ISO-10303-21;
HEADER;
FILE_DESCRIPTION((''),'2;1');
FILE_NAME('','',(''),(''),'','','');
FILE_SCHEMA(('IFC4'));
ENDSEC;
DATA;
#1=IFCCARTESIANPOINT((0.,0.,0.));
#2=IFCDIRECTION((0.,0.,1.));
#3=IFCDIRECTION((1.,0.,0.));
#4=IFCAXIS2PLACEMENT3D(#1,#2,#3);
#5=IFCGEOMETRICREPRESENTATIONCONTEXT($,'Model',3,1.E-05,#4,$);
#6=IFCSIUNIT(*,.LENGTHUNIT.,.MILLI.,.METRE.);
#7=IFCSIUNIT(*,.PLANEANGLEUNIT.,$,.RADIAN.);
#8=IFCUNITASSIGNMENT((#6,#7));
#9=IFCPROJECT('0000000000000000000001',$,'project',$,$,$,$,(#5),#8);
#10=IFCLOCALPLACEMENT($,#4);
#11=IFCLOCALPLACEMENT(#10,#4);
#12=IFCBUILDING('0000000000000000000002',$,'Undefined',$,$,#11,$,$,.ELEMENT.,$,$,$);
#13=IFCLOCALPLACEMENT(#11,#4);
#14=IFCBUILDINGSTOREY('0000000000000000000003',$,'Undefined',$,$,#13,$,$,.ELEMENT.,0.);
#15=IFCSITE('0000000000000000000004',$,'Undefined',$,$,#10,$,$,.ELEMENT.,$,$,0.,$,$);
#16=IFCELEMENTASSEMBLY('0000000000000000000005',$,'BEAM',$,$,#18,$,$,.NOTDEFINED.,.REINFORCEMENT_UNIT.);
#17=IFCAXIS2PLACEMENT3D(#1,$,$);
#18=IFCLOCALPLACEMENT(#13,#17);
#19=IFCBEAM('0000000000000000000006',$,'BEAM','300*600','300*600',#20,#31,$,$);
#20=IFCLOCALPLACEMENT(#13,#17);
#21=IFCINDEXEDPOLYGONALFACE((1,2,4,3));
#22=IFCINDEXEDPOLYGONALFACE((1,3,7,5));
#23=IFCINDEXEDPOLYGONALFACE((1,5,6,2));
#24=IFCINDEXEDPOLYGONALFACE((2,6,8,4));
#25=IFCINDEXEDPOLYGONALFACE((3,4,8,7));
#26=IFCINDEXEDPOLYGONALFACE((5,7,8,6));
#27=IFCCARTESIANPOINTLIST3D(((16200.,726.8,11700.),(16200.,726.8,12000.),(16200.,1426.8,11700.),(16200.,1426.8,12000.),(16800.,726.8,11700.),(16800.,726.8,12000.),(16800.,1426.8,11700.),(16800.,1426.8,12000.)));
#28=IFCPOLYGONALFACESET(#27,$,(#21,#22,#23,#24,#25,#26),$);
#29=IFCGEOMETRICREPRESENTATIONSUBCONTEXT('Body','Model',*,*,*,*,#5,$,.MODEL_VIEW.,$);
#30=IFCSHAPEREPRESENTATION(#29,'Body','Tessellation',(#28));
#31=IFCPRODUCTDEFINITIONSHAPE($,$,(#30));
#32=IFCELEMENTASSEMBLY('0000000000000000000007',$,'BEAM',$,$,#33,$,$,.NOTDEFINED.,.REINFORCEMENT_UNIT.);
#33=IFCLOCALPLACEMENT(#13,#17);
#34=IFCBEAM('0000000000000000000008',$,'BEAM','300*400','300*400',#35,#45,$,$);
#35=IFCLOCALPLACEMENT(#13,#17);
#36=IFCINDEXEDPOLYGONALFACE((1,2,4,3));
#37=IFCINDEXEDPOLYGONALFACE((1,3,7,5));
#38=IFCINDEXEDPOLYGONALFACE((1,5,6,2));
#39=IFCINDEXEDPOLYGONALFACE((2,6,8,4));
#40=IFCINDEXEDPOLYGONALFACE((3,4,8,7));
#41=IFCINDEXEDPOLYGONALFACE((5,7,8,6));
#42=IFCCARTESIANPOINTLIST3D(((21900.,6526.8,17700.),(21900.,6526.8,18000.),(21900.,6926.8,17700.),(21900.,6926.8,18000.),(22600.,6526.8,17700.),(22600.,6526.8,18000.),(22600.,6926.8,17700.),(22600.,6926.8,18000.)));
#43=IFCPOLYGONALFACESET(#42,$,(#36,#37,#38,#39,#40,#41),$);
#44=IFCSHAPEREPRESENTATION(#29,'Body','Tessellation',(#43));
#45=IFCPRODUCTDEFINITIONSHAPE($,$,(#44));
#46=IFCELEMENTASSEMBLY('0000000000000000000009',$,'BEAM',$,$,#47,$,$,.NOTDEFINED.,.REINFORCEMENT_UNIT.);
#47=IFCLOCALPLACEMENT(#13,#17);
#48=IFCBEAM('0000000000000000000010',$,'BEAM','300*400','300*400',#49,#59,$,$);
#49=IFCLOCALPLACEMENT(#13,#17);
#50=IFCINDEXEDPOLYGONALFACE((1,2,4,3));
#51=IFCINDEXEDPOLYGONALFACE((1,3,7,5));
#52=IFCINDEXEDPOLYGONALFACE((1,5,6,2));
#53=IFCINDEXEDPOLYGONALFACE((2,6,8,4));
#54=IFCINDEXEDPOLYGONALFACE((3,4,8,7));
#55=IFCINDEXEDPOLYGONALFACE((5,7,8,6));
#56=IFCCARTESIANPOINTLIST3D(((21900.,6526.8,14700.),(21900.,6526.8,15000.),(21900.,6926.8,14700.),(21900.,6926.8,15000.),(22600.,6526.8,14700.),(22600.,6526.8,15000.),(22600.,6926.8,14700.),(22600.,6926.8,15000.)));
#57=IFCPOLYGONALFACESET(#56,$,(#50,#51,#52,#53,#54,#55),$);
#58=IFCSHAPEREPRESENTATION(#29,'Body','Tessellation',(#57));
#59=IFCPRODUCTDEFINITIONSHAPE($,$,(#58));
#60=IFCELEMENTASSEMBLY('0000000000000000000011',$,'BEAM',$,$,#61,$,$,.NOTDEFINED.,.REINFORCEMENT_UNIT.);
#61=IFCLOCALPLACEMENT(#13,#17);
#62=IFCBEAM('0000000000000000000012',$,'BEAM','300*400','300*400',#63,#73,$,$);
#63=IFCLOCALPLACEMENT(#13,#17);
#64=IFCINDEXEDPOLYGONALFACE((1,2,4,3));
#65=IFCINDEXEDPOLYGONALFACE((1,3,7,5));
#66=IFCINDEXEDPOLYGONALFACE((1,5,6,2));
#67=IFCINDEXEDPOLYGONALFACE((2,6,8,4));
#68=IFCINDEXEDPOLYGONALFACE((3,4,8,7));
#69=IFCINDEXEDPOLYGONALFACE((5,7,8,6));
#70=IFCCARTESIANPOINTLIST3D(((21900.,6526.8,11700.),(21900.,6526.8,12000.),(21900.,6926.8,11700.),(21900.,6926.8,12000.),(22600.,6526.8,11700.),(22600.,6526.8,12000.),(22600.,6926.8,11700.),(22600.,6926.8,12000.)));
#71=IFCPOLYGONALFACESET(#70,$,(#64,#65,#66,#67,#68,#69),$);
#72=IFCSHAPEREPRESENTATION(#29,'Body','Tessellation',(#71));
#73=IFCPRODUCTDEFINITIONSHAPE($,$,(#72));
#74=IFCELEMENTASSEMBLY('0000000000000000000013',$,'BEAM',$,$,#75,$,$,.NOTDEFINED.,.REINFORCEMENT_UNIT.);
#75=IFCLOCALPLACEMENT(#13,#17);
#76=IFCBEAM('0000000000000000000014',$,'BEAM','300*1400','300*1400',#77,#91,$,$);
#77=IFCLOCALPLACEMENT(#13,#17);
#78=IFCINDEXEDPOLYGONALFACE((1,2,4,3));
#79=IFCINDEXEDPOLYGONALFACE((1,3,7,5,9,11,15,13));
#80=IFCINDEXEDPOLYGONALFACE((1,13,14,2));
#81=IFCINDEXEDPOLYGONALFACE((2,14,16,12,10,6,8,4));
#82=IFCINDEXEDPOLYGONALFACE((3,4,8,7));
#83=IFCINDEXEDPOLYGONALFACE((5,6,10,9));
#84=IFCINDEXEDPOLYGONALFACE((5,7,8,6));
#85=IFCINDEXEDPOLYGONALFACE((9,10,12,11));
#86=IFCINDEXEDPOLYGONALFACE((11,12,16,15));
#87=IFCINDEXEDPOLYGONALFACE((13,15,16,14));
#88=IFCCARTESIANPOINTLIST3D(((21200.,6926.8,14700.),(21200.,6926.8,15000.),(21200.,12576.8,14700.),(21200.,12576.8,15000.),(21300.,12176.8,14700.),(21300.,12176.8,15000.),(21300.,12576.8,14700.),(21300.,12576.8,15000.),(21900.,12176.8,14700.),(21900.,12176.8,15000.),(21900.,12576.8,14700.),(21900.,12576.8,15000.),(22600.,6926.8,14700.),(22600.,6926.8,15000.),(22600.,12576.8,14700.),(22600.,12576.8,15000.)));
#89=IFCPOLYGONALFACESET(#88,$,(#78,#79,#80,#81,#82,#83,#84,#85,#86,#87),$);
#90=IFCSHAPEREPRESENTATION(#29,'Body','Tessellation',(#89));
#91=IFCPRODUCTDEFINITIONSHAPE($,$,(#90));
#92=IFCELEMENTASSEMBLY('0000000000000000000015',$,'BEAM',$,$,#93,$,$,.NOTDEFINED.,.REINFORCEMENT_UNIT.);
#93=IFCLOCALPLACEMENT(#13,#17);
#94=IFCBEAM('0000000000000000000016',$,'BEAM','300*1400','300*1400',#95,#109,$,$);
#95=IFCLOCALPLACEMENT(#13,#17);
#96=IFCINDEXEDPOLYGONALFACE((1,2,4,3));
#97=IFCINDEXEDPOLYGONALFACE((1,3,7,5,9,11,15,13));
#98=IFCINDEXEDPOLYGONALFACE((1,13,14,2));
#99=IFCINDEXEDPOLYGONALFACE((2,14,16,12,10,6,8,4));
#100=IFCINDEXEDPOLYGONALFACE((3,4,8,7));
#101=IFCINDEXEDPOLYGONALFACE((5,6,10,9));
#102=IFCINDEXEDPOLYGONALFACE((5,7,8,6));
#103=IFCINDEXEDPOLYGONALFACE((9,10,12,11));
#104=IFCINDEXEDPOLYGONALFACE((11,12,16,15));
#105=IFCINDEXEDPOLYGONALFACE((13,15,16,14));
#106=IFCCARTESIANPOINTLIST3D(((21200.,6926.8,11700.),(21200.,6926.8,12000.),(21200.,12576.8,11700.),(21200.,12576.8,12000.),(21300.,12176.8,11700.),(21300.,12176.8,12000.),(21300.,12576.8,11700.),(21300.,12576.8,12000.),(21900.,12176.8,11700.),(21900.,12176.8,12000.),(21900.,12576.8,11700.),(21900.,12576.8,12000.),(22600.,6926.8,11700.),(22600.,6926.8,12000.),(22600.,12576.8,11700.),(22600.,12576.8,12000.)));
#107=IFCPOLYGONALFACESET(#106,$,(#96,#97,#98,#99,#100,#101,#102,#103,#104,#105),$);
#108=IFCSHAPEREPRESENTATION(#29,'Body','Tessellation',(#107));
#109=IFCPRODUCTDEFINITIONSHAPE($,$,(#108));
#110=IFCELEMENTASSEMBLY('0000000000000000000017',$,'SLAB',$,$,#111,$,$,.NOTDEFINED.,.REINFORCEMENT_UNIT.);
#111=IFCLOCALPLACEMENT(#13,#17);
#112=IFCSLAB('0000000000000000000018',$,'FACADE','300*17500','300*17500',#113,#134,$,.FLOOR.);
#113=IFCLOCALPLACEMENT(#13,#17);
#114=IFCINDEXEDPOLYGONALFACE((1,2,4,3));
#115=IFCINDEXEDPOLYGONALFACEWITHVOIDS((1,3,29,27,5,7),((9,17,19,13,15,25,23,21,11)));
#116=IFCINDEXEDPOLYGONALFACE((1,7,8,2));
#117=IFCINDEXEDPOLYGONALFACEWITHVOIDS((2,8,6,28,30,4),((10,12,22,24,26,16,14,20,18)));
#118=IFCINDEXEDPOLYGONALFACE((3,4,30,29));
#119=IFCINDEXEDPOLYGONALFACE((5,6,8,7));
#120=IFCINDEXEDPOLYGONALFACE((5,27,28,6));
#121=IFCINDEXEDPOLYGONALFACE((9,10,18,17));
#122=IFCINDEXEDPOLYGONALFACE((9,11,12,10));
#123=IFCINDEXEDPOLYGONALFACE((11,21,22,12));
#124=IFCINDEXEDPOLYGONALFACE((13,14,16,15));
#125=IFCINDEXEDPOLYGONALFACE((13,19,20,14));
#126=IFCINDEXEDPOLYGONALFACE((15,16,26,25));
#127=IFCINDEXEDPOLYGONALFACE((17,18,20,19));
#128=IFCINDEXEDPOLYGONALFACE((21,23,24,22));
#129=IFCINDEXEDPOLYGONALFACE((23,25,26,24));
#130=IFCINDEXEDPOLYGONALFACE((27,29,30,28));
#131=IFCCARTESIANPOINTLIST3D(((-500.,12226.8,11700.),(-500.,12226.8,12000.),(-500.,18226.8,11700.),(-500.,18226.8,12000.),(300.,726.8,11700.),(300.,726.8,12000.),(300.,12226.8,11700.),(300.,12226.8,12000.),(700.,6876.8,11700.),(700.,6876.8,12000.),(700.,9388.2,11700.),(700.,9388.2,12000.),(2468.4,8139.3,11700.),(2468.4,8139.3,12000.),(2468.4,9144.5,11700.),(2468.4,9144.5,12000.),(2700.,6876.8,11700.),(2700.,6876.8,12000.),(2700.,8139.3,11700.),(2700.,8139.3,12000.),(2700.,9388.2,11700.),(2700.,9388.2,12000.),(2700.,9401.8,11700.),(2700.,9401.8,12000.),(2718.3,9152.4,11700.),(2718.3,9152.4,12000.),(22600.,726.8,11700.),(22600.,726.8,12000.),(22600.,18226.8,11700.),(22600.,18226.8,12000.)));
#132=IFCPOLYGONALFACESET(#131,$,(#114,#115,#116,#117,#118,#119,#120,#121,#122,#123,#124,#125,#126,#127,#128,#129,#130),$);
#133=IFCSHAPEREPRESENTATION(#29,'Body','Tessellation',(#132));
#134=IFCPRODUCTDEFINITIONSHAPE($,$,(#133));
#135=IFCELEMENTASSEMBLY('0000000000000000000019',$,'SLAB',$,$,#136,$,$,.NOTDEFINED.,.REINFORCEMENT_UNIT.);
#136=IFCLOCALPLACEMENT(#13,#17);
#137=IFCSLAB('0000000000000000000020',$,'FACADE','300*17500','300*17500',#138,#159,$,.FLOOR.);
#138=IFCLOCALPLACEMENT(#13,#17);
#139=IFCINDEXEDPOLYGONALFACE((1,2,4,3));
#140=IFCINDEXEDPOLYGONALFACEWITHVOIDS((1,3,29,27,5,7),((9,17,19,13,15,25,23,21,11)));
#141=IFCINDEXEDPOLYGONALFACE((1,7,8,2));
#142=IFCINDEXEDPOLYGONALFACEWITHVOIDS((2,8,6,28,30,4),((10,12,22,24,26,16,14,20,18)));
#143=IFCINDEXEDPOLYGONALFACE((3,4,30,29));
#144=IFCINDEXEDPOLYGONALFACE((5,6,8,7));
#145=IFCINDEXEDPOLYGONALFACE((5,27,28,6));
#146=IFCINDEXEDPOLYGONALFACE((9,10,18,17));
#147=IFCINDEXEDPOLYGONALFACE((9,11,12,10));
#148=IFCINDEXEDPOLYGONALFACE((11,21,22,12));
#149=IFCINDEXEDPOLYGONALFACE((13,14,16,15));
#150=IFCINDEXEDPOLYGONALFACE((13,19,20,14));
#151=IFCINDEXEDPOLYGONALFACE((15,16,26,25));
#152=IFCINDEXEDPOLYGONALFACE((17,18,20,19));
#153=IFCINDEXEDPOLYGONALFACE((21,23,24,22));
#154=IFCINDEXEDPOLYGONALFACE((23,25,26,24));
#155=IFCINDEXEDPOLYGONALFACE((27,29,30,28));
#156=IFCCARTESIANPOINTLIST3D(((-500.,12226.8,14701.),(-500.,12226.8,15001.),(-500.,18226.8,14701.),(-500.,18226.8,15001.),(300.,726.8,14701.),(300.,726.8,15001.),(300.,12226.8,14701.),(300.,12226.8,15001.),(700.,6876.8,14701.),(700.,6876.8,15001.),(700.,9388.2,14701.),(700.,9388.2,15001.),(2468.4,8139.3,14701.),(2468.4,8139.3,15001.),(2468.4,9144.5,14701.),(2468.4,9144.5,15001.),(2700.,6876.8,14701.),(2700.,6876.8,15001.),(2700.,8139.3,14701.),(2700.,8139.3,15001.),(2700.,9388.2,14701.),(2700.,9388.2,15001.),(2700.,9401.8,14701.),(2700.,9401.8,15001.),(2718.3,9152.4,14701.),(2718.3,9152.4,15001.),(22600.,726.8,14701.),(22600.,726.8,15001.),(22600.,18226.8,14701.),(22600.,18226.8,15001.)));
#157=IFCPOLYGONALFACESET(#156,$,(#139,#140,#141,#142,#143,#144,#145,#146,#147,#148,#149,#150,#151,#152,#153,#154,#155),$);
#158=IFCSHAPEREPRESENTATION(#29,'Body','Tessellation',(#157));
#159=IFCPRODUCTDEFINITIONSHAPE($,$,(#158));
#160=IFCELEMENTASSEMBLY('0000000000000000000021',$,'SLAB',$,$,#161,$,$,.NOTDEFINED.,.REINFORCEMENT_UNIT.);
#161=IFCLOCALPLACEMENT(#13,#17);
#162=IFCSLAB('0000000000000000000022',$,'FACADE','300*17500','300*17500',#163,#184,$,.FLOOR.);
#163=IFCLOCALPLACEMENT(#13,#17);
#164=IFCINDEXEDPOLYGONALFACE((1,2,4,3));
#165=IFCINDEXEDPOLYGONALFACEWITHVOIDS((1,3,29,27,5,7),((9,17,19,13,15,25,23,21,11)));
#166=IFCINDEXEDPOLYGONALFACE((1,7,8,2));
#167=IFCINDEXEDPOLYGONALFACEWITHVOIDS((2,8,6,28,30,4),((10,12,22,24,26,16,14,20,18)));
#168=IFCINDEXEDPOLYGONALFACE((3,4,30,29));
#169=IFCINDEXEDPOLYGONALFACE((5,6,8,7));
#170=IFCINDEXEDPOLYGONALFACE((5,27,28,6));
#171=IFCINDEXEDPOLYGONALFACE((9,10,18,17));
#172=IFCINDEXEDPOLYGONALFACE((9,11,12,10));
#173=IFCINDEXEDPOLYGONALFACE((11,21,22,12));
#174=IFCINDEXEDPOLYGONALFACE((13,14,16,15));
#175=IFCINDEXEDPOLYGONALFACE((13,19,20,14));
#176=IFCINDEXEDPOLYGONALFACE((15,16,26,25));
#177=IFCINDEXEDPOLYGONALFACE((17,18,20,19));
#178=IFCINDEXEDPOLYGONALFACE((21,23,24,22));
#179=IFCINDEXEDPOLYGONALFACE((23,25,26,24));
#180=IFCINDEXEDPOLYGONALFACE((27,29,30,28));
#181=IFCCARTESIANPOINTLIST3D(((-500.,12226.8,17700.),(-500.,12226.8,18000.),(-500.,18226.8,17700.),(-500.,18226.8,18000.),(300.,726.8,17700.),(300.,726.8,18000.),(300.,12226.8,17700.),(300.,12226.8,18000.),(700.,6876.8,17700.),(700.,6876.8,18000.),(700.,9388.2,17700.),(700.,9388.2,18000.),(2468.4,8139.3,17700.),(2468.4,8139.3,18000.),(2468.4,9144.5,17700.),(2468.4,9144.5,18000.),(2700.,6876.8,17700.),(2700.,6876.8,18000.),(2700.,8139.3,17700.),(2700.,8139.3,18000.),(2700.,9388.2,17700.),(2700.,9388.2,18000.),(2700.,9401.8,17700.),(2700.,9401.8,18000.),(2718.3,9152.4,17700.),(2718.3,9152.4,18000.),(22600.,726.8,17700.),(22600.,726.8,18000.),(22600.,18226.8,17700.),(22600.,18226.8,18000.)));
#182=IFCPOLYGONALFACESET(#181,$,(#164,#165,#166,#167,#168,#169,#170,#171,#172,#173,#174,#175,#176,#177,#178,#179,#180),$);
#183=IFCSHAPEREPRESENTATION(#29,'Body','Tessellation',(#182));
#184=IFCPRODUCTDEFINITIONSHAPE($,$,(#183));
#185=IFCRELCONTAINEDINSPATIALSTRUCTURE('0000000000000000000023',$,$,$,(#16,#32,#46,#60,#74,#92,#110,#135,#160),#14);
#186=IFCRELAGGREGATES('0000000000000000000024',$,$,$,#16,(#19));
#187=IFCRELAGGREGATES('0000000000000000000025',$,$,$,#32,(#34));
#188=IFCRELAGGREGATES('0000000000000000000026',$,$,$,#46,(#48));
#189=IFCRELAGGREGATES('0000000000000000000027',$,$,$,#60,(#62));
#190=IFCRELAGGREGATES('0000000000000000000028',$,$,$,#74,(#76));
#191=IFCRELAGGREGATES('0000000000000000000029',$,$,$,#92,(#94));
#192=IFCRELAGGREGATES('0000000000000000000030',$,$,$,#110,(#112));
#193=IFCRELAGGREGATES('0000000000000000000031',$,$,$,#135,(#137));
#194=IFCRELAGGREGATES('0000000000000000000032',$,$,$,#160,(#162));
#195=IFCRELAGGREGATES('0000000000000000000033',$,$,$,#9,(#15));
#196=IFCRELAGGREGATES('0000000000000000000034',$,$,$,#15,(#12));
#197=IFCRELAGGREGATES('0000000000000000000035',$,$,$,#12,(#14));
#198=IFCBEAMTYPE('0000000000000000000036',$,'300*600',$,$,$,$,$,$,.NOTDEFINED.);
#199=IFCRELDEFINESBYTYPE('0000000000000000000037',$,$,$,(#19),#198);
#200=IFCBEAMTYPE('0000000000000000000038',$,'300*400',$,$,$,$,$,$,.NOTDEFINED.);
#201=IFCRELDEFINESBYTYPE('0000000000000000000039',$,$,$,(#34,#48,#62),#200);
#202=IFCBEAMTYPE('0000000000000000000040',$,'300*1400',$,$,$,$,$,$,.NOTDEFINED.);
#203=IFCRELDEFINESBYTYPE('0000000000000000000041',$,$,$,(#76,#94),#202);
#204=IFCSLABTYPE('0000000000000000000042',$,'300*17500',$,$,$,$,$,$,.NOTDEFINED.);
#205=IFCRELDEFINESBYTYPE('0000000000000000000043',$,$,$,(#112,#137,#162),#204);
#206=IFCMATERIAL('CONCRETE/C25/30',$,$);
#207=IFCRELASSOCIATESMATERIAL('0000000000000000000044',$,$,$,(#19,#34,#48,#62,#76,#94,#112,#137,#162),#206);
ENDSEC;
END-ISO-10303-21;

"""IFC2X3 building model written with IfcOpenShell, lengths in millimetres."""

from ifc_helpers import new_model, si_unit, frame, origin_with_axes, origin_2d_with_axis, place, context, subcontext, project, spatial, polyline, rectangle, outline, extrude, boolean, material, type_object, element, aggregate, save


model = new_model("IFC2X3")

# Units and contexts
model_context = context("Model", 3, precision=1e-05, world=origin_with_axes())
body_context = subcontext(model_context, "Body", "Model", "MODEL_VIEW")
ifc_project = project(units=[si_unit("LENGTHUNIT", "METRE", prefix="MILLI"), si_unit("PLANEANGLEUNIT", "RADIAN")], contexts=[model_context])

# Site, building, storey
site_placement = place(None, origin_with_axes())
site = spatial("IfcSite", under=ifc_project, at=site_placement, Name="Undefined", CompositionType="ELEMENT", RefElevation=0.0)
building_placement = place(site_placement, origin_with_axes())
building = spatial("IfcBuilding", under=site, at=building_placement, Name="Undefined", CompositionType="ELEMENT")
storey_placement = place(building_placement, origin_with_axes())
storey = spatial("IfcBuildingStorey", under=building, at=storey_placement, Name="Undefined", CompositionType="ELEMENT", Elevation=0.0)

# Shared definitions
ifc_material = material(Name="CONCRETE/C25/30")

# Element assemblies, beams
beam_type_1 = type_object("IfcBeamType", Name="300*600", PredefinedType="NOTDEFINED")
assembly_1_placement = place(storey_placement, origin_with_axes())
assembly_1 = element("IfcElementAssembly", 1, at=assembly_1_placement, inside=storey, Name="BEAM", AssemblyPlace="NOTDEFINED", PredefinedType="REINFORCEMENT_UNIT")
beam_1_placement = place(assembly_1_placement, frame((16500.0, 1426.8, 11850.0), z_axis=(0.0, 0.0, 1.0), x_axis=(0.0, -1.0, 0.0)))
beam_1 = element("IfcBeam", 2, at=beam_1_placement, type_object=beam_type_1, material=ifc_material, Name="BEAM", Description="300*600", ObjectType="300*600", context=body_context, shape_type="SweptSolid", body=[
    extrude(rectangle(XDim=600.0, YDim=300.0, at=origin_2d_with_axis()), frame((700.0, 0.0, 0.0), z_axis=(-1.0, 0.0, 0.0), x_axis=(0.0, -1.0, 0.0)), (0.0, 0.0, 1.0), 700.0),
])
aggregate(assembly_1, [beam_1])
beam_type_2 = type_object("IfcBeamType", Name="300*400", PredefinedType="NOTDEFINED")
assembly_2_placement = place(storey_placement, origin_with_axes())
assembly_2 = element("IfcElementAssembly", 3, at=assembly_2_placement, inside=storey, Name="BEAM", AssemblyPlace="NOTDEFINED", PredefinedType="REINFORCEMENT_UNIT")
beam_2_placement = place(assembly_2_placement, frame((21900.0, 6726.8, 17850.0), z_axis=(0.0, 0.0, 1.0), x_axis=(1.0, 0.0, 0.0)))
beam_2 = element("IfcBeam", 4, at=beam_2_placement, type_object=beam_type_2, material=ifc_material, Name="BEAM", Description="300*400", ObjectType="300*400", context=body_context, shape_type="SweptSolid", body=[
    extrude(rectangle(XDim=400.0, YDim=300.0, at=origin_2d_with_axis()), frame((700.0, 0.0, 0.0), z_axis=(-1.0, 0.0, 0.0), x_axis=(0.0, -1.0, 0.0)), (0.0, 0.0, 1.0), 700.0),
])
aggregate(assembly_2, [beam_2])
assembly_3_placement = place(storey_placement, origin_with_axes())
assembly_3 = element("IfcElementAssembly", 5, at=assembly_3_placement, inside=storey, Name="BEAM", AssemblyPlace="NOTDEFINED", PredefinedType="REINFORCEMENT_UNIT")
beam_3_placement = place(assembly_3_placement, frame((21900.0, 6726.8, 14850.0), z_axis=(0.0, 0.0, 1.0), x_axis=(1.0, 0.0, 0.0)))
beam_3 = element("IfcBeam", 6, at=beam_3_placement, type_object=beam_type_2, material=ifc_material, Name="BEAM", Description="300*400", ObjectType="300*400", context=body_context, shape_type="SweptSolid", body=[
    extrude(rectangle(XDim=400.0, YDim=300.0, at=origin_2d_with_axis()), frame((700.0, 0.0, 0.0), z_axis=(-1.0, 0.0, 0.0), x_axis=(0.0, -1.0, 0.0)), (0.0, 0.0, 1.0), 700.0),
])
aggregate(assembly_3, [beam_3])
assembly_4_placement = place(storey_placement, origin_with_axes())
assembly_4 = element("IfcElementAssembly", 7, at=assembly_4_placement, inside=storey, Name="BEAM", AssemblyPlace="NOTDEFINED", PredefinedType="REINFORCEMENT_UNIT")
beam_4_placement = place(assembly_4_placement, frame((21900.0, 6726.8, 11850.0), z_axis=(0.0, 0.0, 1.0), x_axis=(1.0, 0.0, 0.0)))
beam_4 = element("IfcBeam", 8, at=beam_4_placement, type_object=beam_type_2, material=ifc_material, Name="BEAM", Description="300*400", ObjectType="300*400", context=body_context, shape_type="SweptSolid", body=[
    extrude(rectangle(XDim=400.0, YDim=300.0, at=origin_2d_with_axis()), frame((700.0, 0.0, 0.0), z_axis=(-1.0, 0.0, 0.0), x_axis=(0.0, -1.0, 0.0)), (0.0, 0.0, 1.0), 700.0),
])
aggregate(assembly_4, [beam_4])
beam_type_3 = type_object("IfcBeamType", Name="300*1400", PredefinedType="NOTDEFINED")
assembly_5_placement = place(storey_placement, origin_with_axes())
assembly_5 = element("IfcElementAssembly", 9, at=assembly_5_placement, inside=storey, Name="BEAM", AssemblyPlace="NOTDEFINED", PredefinedType="REINFORCEMENT_UNIT")
beam_5_placement = place(assembly_5_placement, frame((21900.0, 6926.8, 14850.0), z_axis=(0.0, 0.0, 1.0), x_axis=(0.0, 1.0, 0.0)))
beam_5 = element("IfcBeam", 10, at=beam_5_placement, type_object=beam_type_3, material=ifc_material, Name="BEAM", Description="300*1400", ObjectType="300*1400", context=body_context, shape_type="CSG", body=[
    boolean("DIFFERENCE", extrude(rectangle(XDim=1400.0, YDim=300.0, at=origin_2d_with_axis()), frame((5650.0, 0.0, 0.0), z_axis=(-1.0, 0.0, 0.0), x_axis=(0.0, -1.0, 0.0)), (0.0, 0.0, 1.0), 5650.0), extrude(rectangle(XDim=600.0, YDim=400.0, at=origin_2d_with_axis()), frame((5450.0, 300.0, 150.0), z_axis=(0.0, 0.0, -1.0), x_axis=(0.0, 1.0, 0.0)), (0.0, 0.0, 1.0), 3000.0)),
])
aggregate(assembly_5, [beam_5])
assembly_6_placement = place(storey_placement, origin_with_axes())
assembly_6 = element("IfcElementAssembly", 11, at=assembly_6_placement, inside=storey, Name="BEAM", AssemblyPlace="NOTDEFINED", PredefinedType="REINFORCEMENT_UNIT")
beam_6_placement = place(assembly_6_placement, frame((21900.0, 6926.8, 11850.0), z_axis=(0.0, 0.0, 1.0), x_axis=(0.0, 1.0, 0.0)))
beam_6 = element("IfcBeam", 12, at=beam_6_placement, type_object=beam_type_3, material=ifc_material, Name="BEAM", Description="300*1400", ObjectType="300*1400", context=body_context, shape_type="CSG", body=[
    boolean("DIFFERENCE", extrude(rectangle(XDim=1400.0, YDim=300.0, at=origin_2d_with_axis()), frame((5650.0, 0.0, 0.0), z_axis=(-1.0, 0.0, 0.0), x_axis=(0.0, -1.0, 0.0)), (0.0, 0.0, 1.0), 5650.0), extrude(rectangle(XDim=600.0, YDim=400.0, at=origin_2d_with_axis()), frame((5450.0, 300.0, 150.0), z_axis=(0.0, 0.0, -1.0), x_axis=(0.0, 1.0, 0.0)), (0.0, 0.0, 1.0), 3000.0)),
])
aggregate(assembly_6, [beam_6])

# Element assemblies, slabs
assembly_7_placement = place(storey_placement, origin_with_axes())
assembly_7 = element("IfcElementAssembly", 13, at=assembly_7_placement, inside=storey, Name="SLAB", AssemblyPlace="NOTDEFINED", PredefinedType="REINFORCEMENT_UNIT")
slab_type = type_object("IfcSlabType", Name="300*17500", PredefinedType="NOTDEFINED")
slab_1_placement = place(assembly_7_placement, frame((22600.0, 726.8, 11850.0), z_axis=(0.0, 0.0, 1.0), x_axis=(0.0, 1.0, 0.0)))
slab_1 = element("IfcSlab", 14, at=slab_1_placement, type_object=slab_type, material=ifc_material, Name="FACADE", Description="300*17500", ObjectType="300*17500", PredefinedType="FLOOR", context=body_context, shape_type="CSG", body=[
    boolean("DIFFERENCE", extrude(outline(polyline([(0.0, 0.0), (17500.0, 0.0), (17500.0, 23100.0), (11500.0, 23100.0), (11500.0, 22300.0), (0.0, 22300.0), (0.0, 0.0), (0.0, 0.0)])), frame((0.0, 0.0, -150.0), z_axis=(0.0, 0.0, 1.0), x_axis=(1.0, 0.0, 0.0)), (0.0, 0.0, 1.0), 300.0), extrude(outline(polyline([(0.0, 0.0), (2000.0, 0.0), (2000.0, -13.6), (2018.3, 235.8), (1768.4, 243.7), (1768.4, 1248.9), (2000.0, 1248.9), (2000.0, 2511.4), (0.0, 2511.4), (0.0, 0.0), (0.0, 0.0)])), frame((8661.4, 21900.0, 152.5), z_axis=(0.0, 0.0, -1.0), x_axis=(0.0, -1.0, 0.0)), (0.0, 0.0, 1.0), 305.0)),
])
aggregate(assembly_7, [slab_1])
assembly_8_placement = place(storey_placement, origin_with_axes())
assembly_8 = element("IfcElementAssembly", 15, at=assembly_8_placement, inside=storey, Name="SLAB", AssemblyPlace="NOTDEFINED", PredefinedType="REINFORCEMENT_UNIT")
slab_2_placement = place(assembly_8_placement, frame((22600.0, 726.8, 14851.0), z_axis=(0.0, 0.0, 1.0), x_axis=(0.0, 1.0, 0.0)))
slab_2 = element("IfcSlab", 16, at=slab_2_placement, type_object=slab_type, material=ifc_material, Name="FACADE", Description="300*17500", ObjectType="300*17500", PredefinedType="FLOOR", context=body_context, shape_type="CSG", body=[
    boolean("DIFFERENCE", extrude(outline(polyline([(0.0, 0.0), (17500.0, 0.0), (17500.0, 23100.0), (11500.0, 23100.0), (11500.0, 22300.0), (0.0, 22300.0), (0.0, 0.0), (0.0, 0.0)])), frame((0.0, 0.0, -150.0), z_axis=(0.0, 0.0, 1.0), x_axis=(1.0, 0.0, 0.0)), (0.0, 0.0, 1.0), 300.0), extrude(outline(polyline([(0.0, 0.0), (2000.0, 0.0), (2000.0, -13.6), (2018.3, 235.8), (1768.4, 243.7), (1768.4, 1248.9), (2000.0, 1248.9), (2000.0, 2511.4), (0.0, 2511.4), (0.0, 0.0), (0.0, 0.0)])), frame((8661.4, 21900.0, 151.5), z_axis=(0.0, 0.0, -1.0), x_axis=(0.0, -1.0, 0.0)), (0.0, 0.0, 1.0), 305.0)),
])
aggregate(assembly_8, [slab_2])
assembly_9_placement = place(storey_placement, origin_with_axes())
assembly_9 = element("IfcElementAssembly", 17, at=assembly_9_placement, inside=storey, Name="SLAB", AssemblyPlace="NOTDEFINED", PredefinedType="REINFORCEMENT_UNIT")
slab_3_placement = place(assembly_9_placement, frame((22600.0, 726.8, 17850.0), z_axis=(0.0, 0.0, 1.0), x_axis=(0.0, 1.0, 0.0)))
slab_3 = element("IfcSlab", 18, at=slab_3_placement, type_object=slab_type, material=ifc_material, Name="FACADE", Description="300*17500", ObjectType="300*17500", PredefinedType="FLOOR", context=body_context, shape_type="CSG", body=[
    boolean("DIFFERENCE", extrude(outline(polyline([(0.0, 0.0), (17500.0, 0.0), (17500.0, 23100.0), (11500.0, 23100.0), (11500.0, 22300.0), (0.0, 22300.0), (0.0, 0.0), (0.0, 0.0)])), frame((0.0, 0.0, -150.0), z_axis=(0.0, 0.0, 1.0), x_axis=(1.0, 0.0, 0.0)), (0.0, 0.0, 1.0), 300.0), extrude(outline(polyline([(0.0, 0.0), (2000.0, 0.0), (2000.0, -13.6), (2018.3, 235.8), (1768.4, 243.7), (1768.4, 1248.9), (2000.0, 1248.9), (2000.0, 2511.4), (0.0, 2511.4), (0.0, 0.0), (0.0, 0.0)])), frame((8661.4, 21900.0, 151.5), z_axis=(0.0, 0.0, -1.0), x_axis=(0.0, -1.0, 0.0)), (0.0, 0.0, 1.0), 305.0)),
])
aggregate(assembly_9, [slab_3])

save(model, "model.ifc")
